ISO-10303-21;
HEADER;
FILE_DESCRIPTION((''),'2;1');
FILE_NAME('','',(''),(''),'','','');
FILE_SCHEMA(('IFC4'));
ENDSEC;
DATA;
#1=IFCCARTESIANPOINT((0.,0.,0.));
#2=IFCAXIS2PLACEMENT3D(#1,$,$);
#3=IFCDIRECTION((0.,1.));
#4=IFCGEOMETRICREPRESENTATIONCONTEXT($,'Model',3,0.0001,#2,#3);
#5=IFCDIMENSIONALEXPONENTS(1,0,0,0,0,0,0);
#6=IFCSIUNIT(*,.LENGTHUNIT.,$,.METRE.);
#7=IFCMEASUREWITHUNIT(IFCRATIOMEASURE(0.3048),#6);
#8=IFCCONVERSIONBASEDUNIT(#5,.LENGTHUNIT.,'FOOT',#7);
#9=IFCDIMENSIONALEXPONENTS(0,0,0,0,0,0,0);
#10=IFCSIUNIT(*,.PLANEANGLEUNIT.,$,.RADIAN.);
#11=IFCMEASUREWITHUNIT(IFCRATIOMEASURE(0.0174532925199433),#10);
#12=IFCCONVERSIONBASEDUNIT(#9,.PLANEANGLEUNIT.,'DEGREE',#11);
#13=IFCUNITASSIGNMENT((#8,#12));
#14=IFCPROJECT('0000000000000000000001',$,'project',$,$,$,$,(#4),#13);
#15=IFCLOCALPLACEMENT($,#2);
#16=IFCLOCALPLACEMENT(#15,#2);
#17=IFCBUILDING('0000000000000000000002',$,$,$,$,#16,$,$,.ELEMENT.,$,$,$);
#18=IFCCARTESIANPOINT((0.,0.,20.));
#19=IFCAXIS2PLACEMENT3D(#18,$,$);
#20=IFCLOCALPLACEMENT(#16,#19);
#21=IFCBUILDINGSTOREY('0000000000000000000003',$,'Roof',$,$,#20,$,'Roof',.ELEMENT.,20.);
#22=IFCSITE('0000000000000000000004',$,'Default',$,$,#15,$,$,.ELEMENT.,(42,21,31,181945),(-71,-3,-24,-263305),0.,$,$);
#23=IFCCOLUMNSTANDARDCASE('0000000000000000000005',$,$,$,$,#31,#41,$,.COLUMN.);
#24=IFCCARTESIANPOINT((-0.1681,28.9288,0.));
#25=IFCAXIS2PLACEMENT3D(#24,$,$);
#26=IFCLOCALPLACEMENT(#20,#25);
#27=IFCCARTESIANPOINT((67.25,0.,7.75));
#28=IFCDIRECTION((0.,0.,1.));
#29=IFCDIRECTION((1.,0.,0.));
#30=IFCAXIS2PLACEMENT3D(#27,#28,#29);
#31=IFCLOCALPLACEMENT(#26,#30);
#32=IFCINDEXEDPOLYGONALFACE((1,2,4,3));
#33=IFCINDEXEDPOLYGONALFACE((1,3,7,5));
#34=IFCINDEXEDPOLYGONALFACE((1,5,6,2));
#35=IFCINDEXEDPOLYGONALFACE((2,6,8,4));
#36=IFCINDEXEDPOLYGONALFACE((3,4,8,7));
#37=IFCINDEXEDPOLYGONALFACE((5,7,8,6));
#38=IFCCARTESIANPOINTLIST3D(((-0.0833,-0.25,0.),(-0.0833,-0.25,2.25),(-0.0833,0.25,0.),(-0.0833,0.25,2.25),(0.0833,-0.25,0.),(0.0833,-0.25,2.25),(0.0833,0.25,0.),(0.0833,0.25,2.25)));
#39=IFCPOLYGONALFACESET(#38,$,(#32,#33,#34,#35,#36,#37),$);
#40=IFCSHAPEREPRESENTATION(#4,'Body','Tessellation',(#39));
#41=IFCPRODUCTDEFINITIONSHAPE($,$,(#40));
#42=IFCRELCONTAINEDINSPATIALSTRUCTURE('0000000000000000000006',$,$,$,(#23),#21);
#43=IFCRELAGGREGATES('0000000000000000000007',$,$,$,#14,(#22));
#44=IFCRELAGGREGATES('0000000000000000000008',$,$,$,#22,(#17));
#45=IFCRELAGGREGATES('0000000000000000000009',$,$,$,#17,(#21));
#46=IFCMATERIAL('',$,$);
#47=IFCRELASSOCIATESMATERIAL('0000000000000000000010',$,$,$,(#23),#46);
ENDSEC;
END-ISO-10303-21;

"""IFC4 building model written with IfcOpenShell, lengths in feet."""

from ifc_helpers import new_model, entity, si_unit, converted_unit, direction, frame, origin, place, context, project, spatial, rectangle, extrude, material, element, save


model = new_model("IFC4")

# Units and contexts
model_context = context("Model", 3, precision=0.0001, world=origin(), true_north=direction((0.0, 1.0)))
ifc_project = project(units=[converted_unit("LENGTHUNIT", "FOOT", entity("IfcRatioMeasure", 0.3048), si_unit("LENGTHUNIT", "METRE"), dimensions=[1, 0, 0, 0, 0, 0, 0]), converted_unit("PLANEANGLEUNIT", "DEGREE", entity("IfcRatioMeasure", 0.0174532925199433), si_unit("PLANEANGLEUNIT", "RADIAN"), dimensions=[0, 0, 0, 0, 0, 0, 0])], contexts=[model_context])

# Site, building, storey
site_placement = place(None, origin())
site = spatial("IfcSite", under=ifc_project, at=site_placement, Name="Default", CompositionType="ELEMENT", RefLatitude=(42, 21, 31, 181945), RefLongitude=(-71, -3, -24, -263305), RefElevation=0.0)
building_placement = place(site_placement, origin())
building = spatial("IfcBuilding", under=site, at=building_placement, CompositionType="ELEMENT")
storey_placement = place(building_placement, frame((0.0, 0.0, 20.0)))
storey = spatial("IfcBuildingStorey", under=building, at=storey_placement, Name="Roof", LongName="Roof", CompositionType="ELEMENT", Elevation=20.0)

# Column
ifc_material_1 = material(Name="")
placement = place(storey_placement, frame((-0.1681, 28.9288, 0.0)))
for number, where, z_axis, x_axis in (
    (1, (67.25, 0.0, 7.75), (0.0, 0.0, 1.0), (1.0, 0.0, 0.0)),
):
    element("IfcColumnStandardCase", number, at=place(placement, frame(where, z_axis=z_axis, x_axis=x_axis)), inside=storey, material=ifc_material_1, PredefinedType="COLUMN", context=model_context, shape_type="SweptSolid", body=[
        extrude(rectangle(XDim=0.1667, YDim=0.5), origin(), (0.0, 0.0, 1.0), 2.25),
    ])

save(model, "model.ifc")
